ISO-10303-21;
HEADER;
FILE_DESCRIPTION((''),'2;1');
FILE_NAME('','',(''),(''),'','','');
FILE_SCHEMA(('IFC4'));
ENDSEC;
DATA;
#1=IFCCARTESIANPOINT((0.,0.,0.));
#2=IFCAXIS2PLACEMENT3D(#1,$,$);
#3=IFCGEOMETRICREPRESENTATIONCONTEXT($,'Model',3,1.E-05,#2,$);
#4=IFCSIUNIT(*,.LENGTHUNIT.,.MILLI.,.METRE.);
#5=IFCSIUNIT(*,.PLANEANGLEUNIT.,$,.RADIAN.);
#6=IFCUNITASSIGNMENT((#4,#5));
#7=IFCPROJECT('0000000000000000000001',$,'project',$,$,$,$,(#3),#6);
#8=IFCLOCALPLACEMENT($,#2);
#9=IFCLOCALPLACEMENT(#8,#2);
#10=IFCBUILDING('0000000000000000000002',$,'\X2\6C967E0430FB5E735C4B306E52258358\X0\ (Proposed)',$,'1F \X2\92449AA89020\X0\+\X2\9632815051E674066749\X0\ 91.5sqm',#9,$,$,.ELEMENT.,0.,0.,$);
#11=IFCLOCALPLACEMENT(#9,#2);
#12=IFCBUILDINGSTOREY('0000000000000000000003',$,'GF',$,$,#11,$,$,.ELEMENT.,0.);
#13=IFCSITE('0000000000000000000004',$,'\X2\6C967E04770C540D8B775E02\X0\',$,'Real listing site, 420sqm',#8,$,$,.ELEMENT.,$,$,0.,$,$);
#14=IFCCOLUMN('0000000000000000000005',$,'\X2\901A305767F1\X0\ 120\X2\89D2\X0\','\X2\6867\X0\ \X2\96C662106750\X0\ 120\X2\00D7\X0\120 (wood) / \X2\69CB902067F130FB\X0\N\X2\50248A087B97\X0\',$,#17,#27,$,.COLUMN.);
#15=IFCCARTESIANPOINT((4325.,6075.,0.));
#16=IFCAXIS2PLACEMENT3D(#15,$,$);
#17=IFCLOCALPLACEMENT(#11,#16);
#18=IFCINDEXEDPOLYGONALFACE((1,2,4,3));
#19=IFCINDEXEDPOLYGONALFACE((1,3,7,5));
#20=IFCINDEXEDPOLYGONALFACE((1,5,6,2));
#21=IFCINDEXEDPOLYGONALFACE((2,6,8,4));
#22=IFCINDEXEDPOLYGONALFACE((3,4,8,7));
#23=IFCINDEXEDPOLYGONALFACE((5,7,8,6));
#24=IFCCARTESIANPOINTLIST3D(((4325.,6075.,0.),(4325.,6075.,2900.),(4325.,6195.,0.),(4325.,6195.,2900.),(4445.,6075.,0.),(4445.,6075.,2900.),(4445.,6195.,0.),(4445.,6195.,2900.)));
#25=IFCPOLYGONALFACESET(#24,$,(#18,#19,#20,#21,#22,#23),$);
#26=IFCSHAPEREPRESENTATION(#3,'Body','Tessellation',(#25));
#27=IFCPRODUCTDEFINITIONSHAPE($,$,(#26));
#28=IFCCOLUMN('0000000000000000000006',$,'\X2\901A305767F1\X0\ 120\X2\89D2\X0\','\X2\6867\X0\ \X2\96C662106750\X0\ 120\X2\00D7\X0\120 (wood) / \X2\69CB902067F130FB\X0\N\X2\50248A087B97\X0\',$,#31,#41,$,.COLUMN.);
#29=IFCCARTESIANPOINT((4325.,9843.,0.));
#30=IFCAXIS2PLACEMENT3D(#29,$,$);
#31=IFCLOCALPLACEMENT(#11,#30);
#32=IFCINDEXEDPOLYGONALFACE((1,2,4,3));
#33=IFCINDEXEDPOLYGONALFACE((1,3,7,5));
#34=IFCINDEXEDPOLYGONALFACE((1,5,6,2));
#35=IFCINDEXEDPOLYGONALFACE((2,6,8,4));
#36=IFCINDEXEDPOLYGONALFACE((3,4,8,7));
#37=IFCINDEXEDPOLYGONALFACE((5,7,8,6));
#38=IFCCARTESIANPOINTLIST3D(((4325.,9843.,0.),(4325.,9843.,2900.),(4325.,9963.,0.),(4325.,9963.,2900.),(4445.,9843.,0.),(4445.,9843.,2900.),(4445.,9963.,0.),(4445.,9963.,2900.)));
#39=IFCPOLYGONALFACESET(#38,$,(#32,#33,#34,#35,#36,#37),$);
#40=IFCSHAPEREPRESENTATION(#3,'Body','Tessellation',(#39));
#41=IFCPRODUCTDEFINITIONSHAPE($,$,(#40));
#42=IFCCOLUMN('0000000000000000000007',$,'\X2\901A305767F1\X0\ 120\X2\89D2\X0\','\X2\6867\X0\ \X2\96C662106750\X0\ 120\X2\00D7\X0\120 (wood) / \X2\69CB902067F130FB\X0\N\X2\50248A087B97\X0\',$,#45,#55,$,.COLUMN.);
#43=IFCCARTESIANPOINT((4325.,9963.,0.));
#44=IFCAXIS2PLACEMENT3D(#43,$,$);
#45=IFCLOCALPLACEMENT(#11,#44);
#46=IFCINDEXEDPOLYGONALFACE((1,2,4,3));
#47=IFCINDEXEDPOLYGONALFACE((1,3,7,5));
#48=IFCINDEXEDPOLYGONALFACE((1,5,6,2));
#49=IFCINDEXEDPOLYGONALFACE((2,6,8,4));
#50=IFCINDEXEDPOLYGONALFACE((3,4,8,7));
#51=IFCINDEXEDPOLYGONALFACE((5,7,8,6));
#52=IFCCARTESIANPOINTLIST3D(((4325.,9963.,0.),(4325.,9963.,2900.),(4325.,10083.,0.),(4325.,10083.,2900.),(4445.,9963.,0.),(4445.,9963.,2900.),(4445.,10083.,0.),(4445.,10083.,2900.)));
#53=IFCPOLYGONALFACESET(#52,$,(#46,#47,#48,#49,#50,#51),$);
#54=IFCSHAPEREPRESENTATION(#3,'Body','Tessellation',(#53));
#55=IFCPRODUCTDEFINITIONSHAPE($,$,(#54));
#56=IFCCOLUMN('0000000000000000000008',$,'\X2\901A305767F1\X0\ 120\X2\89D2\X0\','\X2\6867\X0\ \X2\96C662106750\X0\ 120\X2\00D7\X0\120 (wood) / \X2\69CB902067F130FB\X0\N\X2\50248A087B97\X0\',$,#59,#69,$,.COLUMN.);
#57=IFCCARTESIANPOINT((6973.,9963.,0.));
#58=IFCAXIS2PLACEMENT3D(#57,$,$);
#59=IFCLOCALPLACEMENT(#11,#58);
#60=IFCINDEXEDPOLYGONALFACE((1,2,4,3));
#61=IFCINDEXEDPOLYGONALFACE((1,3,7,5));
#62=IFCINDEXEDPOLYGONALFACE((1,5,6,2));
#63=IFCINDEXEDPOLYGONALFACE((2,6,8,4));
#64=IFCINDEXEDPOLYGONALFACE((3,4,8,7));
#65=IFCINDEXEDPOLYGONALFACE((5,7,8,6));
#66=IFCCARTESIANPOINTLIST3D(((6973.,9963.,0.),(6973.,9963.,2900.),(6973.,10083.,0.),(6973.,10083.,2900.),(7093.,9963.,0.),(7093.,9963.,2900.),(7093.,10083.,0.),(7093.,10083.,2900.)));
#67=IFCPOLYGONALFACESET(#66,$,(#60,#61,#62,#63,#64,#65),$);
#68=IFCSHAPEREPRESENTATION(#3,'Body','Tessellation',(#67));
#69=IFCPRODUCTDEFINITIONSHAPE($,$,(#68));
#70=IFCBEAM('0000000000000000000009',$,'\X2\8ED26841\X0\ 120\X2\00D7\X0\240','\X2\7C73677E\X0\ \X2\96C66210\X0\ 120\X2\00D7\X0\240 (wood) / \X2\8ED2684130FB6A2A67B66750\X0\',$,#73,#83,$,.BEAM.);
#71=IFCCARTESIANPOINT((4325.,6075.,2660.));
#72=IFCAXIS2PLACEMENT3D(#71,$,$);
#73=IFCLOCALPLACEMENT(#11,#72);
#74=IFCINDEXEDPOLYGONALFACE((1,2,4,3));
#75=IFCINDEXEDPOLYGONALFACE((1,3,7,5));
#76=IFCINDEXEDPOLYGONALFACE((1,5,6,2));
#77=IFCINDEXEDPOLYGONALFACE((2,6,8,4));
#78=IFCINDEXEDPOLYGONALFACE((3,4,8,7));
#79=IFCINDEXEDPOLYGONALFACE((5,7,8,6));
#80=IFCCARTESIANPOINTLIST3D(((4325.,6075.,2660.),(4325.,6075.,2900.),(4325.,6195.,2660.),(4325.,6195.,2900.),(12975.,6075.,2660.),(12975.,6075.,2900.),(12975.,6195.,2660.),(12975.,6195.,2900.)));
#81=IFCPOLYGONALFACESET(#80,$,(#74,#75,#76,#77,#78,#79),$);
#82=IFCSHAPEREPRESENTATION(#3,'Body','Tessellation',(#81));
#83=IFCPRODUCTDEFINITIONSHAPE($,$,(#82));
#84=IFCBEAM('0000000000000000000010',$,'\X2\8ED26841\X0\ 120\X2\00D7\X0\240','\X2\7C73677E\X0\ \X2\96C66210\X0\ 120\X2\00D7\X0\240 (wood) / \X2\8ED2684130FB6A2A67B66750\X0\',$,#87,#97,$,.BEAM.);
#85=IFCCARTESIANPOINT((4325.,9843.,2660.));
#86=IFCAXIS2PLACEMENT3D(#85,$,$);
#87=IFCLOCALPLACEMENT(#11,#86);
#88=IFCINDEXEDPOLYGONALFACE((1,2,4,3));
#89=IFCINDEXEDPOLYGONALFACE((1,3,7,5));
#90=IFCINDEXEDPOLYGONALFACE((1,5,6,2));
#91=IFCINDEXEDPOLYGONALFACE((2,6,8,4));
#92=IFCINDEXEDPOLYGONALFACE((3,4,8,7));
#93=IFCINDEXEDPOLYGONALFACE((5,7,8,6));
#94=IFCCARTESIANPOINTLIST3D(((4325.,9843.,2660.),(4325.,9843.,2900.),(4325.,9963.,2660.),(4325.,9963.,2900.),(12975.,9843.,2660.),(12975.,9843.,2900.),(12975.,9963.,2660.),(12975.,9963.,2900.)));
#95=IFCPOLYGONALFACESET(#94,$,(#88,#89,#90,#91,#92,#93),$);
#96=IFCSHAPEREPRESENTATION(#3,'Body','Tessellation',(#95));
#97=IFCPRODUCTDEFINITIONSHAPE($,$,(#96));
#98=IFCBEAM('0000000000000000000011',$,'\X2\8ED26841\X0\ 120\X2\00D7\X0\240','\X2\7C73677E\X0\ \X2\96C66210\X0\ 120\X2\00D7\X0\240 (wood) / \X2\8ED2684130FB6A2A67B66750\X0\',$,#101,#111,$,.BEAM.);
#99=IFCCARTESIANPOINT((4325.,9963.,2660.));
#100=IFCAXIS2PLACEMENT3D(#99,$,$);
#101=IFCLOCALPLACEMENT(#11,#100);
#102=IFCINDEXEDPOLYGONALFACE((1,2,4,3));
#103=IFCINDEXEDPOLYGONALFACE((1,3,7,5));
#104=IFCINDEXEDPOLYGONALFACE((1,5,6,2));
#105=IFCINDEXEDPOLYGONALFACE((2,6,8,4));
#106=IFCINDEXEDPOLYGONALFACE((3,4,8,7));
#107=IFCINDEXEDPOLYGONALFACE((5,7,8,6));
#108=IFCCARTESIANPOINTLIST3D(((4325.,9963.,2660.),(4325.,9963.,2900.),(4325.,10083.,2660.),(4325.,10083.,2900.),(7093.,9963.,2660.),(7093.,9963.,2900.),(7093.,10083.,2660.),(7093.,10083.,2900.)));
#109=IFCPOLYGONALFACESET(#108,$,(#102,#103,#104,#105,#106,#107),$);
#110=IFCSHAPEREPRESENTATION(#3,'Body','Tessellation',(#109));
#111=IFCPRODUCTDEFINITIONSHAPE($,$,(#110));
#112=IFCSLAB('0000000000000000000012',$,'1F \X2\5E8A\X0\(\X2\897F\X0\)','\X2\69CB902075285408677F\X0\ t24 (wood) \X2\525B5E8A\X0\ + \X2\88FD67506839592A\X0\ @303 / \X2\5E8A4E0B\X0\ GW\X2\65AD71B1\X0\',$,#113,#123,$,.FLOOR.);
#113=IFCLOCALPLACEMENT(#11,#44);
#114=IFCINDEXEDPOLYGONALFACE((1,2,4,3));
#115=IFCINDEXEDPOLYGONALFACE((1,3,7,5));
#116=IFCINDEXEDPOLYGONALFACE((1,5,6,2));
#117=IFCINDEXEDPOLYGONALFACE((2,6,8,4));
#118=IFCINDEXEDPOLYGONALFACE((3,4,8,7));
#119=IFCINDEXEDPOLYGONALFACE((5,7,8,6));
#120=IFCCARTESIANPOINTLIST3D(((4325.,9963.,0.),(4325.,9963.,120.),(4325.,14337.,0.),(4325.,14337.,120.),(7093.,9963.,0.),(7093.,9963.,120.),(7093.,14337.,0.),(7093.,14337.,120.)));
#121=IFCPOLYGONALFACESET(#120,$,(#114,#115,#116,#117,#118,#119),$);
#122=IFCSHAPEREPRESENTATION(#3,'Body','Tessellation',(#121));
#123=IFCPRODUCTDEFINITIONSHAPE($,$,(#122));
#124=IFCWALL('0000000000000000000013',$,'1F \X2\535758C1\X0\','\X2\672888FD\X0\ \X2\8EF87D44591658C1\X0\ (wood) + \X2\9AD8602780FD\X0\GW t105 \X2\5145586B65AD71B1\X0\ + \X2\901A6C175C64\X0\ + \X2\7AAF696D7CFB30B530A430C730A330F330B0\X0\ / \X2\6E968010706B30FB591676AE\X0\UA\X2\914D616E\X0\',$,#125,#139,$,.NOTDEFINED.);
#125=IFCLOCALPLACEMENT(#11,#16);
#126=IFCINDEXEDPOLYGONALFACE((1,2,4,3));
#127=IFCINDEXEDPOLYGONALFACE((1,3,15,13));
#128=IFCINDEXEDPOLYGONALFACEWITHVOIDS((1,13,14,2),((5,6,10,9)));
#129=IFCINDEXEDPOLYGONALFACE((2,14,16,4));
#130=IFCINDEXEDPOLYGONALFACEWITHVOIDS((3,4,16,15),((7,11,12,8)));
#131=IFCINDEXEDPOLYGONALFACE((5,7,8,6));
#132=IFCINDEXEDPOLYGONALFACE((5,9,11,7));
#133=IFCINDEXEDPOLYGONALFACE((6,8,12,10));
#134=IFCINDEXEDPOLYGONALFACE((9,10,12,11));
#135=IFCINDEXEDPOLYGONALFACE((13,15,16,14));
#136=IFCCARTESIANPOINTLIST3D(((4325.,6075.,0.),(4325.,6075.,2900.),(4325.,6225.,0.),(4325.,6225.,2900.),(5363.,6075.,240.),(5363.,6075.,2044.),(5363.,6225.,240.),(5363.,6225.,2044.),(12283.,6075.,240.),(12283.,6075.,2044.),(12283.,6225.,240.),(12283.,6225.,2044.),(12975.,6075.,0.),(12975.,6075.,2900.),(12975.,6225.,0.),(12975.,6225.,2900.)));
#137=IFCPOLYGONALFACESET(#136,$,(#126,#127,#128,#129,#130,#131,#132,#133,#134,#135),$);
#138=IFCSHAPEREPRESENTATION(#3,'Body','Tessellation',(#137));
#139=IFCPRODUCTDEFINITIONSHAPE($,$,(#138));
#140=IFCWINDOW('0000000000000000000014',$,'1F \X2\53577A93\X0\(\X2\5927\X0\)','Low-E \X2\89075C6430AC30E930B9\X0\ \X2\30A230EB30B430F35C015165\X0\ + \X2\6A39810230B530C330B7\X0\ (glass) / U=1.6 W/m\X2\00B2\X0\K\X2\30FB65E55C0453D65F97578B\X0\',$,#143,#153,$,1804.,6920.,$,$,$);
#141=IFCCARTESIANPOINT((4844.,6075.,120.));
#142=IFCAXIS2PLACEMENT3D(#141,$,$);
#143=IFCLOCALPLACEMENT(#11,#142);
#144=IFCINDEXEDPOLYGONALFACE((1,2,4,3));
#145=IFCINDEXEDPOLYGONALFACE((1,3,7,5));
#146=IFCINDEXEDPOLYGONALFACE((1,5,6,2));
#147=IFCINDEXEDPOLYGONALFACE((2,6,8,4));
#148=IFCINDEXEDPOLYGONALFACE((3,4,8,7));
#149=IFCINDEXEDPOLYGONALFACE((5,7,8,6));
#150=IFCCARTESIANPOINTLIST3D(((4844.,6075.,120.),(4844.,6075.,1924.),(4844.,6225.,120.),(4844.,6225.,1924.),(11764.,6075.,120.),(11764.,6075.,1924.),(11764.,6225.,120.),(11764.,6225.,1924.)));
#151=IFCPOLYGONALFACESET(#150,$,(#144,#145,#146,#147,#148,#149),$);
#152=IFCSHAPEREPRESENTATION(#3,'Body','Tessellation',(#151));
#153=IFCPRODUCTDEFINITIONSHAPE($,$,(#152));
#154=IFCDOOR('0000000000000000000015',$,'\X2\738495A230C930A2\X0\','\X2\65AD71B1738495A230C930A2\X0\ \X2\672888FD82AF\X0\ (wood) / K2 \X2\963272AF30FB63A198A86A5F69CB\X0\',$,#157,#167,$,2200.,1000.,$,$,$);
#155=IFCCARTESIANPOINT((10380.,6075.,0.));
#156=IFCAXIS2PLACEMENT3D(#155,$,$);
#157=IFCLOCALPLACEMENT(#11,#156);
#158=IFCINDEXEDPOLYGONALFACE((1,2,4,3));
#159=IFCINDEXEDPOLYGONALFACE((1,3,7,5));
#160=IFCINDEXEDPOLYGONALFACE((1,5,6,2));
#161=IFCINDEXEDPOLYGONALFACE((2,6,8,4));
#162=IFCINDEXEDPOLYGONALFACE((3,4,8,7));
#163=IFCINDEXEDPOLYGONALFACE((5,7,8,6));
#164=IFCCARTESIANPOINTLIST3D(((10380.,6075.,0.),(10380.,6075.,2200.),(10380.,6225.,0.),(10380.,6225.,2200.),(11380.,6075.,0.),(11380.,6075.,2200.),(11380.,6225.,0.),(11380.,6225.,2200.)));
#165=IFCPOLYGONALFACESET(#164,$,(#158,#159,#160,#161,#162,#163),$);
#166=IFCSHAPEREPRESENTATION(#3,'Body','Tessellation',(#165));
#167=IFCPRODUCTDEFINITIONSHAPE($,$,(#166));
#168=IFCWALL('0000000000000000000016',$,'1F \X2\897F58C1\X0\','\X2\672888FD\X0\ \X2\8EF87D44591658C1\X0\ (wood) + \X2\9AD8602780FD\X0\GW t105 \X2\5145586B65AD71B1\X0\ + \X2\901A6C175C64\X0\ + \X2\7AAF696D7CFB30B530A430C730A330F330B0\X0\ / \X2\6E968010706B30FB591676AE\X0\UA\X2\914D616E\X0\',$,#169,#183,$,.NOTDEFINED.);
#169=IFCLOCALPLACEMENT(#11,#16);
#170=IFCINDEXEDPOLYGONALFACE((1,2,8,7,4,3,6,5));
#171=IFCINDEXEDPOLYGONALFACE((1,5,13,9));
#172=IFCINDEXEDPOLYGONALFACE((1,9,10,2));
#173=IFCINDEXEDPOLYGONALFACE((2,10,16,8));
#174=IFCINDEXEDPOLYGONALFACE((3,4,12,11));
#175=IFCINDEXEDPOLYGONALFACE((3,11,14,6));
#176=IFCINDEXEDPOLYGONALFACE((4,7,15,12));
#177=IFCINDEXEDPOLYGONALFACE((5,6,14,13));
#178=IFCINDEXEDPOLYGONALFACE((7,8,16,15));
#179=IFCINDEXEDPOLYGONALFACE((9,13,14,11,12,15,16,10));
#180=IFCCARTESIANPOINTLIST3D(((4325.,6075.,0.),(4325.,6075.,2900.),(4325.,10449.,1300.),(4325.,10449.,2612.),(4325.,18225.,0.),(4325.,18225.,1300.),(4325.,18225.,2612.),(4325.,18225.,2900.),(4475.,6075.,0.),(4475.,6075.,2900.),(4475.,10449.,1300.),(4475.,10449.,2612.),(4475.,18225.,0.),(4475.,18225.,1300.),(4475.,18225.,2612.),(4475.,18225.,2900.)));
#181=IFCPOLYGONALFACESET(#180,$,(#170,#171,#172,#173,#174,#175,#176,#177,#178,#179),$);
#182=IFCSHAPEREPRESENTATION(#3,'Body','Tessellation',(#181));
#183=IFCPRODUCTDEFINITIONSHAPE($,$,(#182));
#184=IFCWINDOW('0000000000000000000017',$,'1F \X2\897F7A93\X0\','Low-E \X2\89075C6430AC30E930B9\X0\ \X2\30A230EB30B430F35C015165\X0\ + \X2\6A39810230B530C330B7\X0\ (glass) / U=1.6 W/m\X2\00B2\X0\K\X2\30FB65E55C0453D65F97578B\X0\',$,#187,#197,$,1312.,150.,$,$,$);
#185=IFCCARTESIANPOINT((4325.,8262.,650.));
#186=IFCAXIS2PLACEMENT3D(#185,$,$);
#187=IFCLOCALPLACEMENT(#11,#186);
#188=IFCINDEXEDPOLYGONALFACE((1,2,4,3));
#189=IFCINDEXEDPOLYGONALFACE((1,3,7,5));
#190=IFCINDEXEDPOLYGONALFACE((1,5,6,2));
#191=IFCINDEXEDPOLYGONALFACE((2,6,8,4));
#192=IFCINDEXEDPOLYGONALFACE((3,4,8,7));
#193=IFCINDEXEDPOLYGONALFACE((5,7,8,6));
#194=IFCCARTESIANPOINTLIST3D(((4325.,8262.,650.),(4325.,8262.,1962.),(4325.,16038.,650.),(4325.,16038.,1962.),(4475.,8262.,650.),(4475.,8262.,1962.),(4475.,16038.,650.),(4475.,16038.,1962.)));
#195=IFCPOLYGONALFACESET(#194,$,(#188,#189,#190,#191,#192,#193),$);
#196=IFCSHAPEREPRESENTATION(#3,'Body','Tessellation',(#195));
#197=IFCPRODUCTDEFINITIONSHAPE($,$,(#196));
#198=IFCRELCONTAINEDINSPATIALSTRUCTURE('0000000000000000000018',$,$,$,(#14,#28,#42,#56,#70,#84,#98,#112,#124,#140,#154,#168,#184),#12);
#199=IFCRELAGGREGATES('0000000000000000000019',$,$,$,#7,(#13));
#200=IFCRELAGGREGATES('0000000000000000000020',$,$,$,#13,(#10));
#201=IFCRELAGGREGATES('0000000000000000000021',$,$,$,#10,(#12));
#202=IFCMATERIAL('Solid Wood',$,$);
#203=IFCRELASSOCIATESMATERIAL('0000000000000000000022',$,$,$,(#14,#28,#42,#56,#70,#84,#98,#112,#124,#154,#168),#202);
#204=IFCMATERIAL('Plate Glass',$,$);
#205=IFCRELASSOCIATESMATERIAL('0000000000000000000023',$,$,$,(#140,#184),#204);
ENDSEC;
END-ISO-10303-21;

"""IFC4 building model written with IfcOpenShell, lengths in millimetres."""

from ifc_helpers import new_model, si_unit, frame, frame_2d, origin, place, context, project, spatial, rectangle, extrude, material, element, fill, save


model = new_model("IFC4")

# Units and contexts
model_context = context("Model", 3, precision=1e-05, world=origin())
ifc_project = project(units=[si_unit("LENGTHUNIT", "METRE", prefix="MILLI"), si_unit("PLANEANGLEUNIT", "RADIAN")], contexts=[model_context])

# Site, building, storey
site_placement = place(None, origin())
site = spatial("IfcSite", under=ifc_project, at=site_placement, Name="沖縄県名護市", ObjectType="Real listing site, 420sqm", CompositionType="ELEMENT", RefElevation=0.0)
building_placement = place(site_placement, origin())
building = spatial("IfcBuilding", under=site, at=building_placement, Name="沖縄・平屋の別荘 (Proposed)", ObjectType="1F 鉄骨造+防腐処理杉 91.5sqm", CompositionType="ELEMENT", ElevationOfRefHeight=0.0, ElevationOfTerrain=0.0)
storey_placement = place(building_placement, origin())
storey = spatial("IfcBuildingStorey", under=building, at=storey_placement, Name="GF", CompositionType="ELEMENT", Elevation=0.0)

# Columns
ifc_material_1 = material(Name="Solid Wood")
column_1_placement = place(storey_placement, frame((4325.0, 6075.0, 0.0)))
element("IfcColumn", 1, at=column_1_placement, inside=storey, material=ifc_material_1, Name="通し柱 120角", Description="桧 集成材 120×120 (wood) / 構造柱・N値計算", PredefinedType="COLUMN", context=model_context, shape_type="SweptSolid", body=[
    extrude(rectangle(XDim=120.0, YDim=120.0, at=frame_2d((60.0, 60.0))), frame((4325.0, 6075.0, 0.0)), (0.0, 0.0, 1.0), 2900.0),
])
column_2_placement = place(storey_placement, frame((4325.0, 9843.0, 0.0)))
element("IfcColumn", 2, at=column_2_placement, inside=storey, material=ifc_material_1, Name="通し柱 120角", Description="桧 集成材 120×120 (wood) / 構造柱・N値計算", PredefinedType="COLUMN", context=model_context, shape_type="SweptSolid", body=[
    extrude(rectangle(XDim=120.0, YDim=120.0, at=frame_2d((60.0, 60.0))), frame((4325.0, 9843.0, 0.0)), (0.0, 0.0, 1.0), 2900.0),
])
column_3_placement = place(storey_placement, frame((4325.0, 9963.0, 0.0)))
element("IfcColumn", 3, at=column_3_placement, inside=storey, material=ifc_material_1, Name="通し柱 120角", Description="桧 集成材 120×120 (wood) / 構造柱・N値計算", PredefinedType="COLUMN", context=model_context, shape_type="SweptSolid", body=[
    extrude(rectangle(XDim=120.0, YDim=120.0, at=frame_2d((60.0, 60.0))), frame((4325.0, 9963.0, 0.0)), (0.0, 0.0, 1.0), 2900.0),
])
column_4_placement = place(storey_placement, frame((6973.0, 9963.0, 0.0)))
element("IfcColumn", 4, at=column_4_placement, inside=storey, material=ifc_material_1, Name="通し柱 120角", Description="桧 集成材 120×120 (wood) / 構造柱・N値計算", PredefinedType="COLUMN", context=model_context, shape_type="SweptSolid", body=[
    extrude(rectangle(XDim=120.0, YDim=120.0, at=frame_2d((60.0, 60.0))), frame((6973.0, 9963.0, 0.0)), (0.0, 0.0, 1.0), 2900.0),
])

# Beams
beam_1_placement = place(storey_placement, frame((4325.0, 6075.0, 2660.0)))
element("IfcBeam", 5, at=beam_1_placement, inside=storey, material=ifc_material_1, Name="軒桁 120×240", Description="米松 集成 120×240 (wood) / 軒桁・横架材", PredefinedType="BEAM", context=model_context, shape_type="SweptSolid", body=[
    extrude(rectangle(XDim=8650.0, YDim=120.0, at=frame_2d((4325.0, 60.0))), frame((4325.0, 6075.0, 2660.0)), (0.0, 0.0, 1.0), 240.0),
])
beam_2_placement = place(storey_placement, frame((4325.0, 9843.0, 2660.0)))
element("IfcBeam", 6, at=beam_2_placement, inside=storey, material=ifc_material_1, Name="軒桁 120×240", Description="米松 集成 120×240 (wood) / 軒桁・横架材", PredefinedType="BEAM", context=model_context, shape_type="SweptSolid", body=[
    extrude(rectangle(XDim=8650.0, YDim=120.0, at=frame_2d((4325.0, 60.0))), frame((4325.0, 9843.0, 2660.0)), (0.0, 0.0, 1.0), 240.0),
])
beam_3_placement = place(storey_placement, frame((4325.0, 9963.0, 2660.0)))
element("IfcBeam", 7, at=beam_3_placement, inside=storey, material=ifc_material_1, Name="軒桁 120×240", Description="米松 集成 120×240 (wood) / 軒桁・横架材", PredefinedType="BEAM", context=model_context, shape_type="SweptSolid", body=[
    extrude(rectangle(XDim=2768.0, YDim=120.0, at=frame_2d((1384.0, 60.0))), frame((4325.0, 9963.0, 2660.0)), (0.0, 0.0, 1.0), 240.0),
])

# Slab
slab_1_placement = place(storey_placement, frame((4325.0, 9963.0, 0.0)))
element("IfcSlab", 8, at=slab_1_placement, inside=storey, material=ifc_material_1, Name="1F 床(西)", Description="構造用合板 t24 (wood) 剛床 + 製材根太 @303 / 床下 GW断熱", PredefinedType="FLOOR", context=model_context, shape_type="SweptSolid", body=[
    extrude(rectangle(XDim=2768.0, YDim=4374.0, at=frame_2d((1384.0, 2187.0))), frame((4325.0, 9963.0, 0.0)), (0.0, 0.0, 1.0), 120.0),
])

# Wall, openings, window, door
wall_1_placement = place(storey_placement, frame((4325.0, 6075.0, 0.0)))
wall_1 = element("IfcWall", 9, at=wall_1_placement, inside=storey, material=ifc_material_1, Name="1F 南壁", Description="木製 軸組外壁 (wood) + 高性能GW t105 充填断熱 + 通気層 + 窯業系サイディング / 準耐火・外皮UA配慮", PredefinedType="NOTDEFINED", context=model_context, shape_type="SweptSolid", body=[
    extrude(rectangle(XDim=8650.0, YDim=150.0, at=frame_2d((4325.0, 75.0))), frame((4325.0, 6075.0, 0.0)), (0.0, 0.0, 1.0), 2900.0),
])
opening_1_placement = place(storey_placement, frame((4844.0, 6075.0, 120.0)))
opening_1 = element("IfcOpeningElement", 10, at=opening_1_placement, cuts=wall_1, PredefinedType="NOTDEFINED", context=model_context, shape_type="SweptSolid", body=[
    extrude(rectangle(XDim=6920.0, YDim=150.0, at=frame_2d((3460.0, 75.0))), frame((4844.0, 6075.0, 120.0)), (0.0, 0.0, 1.0), 1804.0),
])
opening_2_placement = place(storey_placement, frame((10380.0, 6075.0, 0.0)))
opening_2 = element("IfcOpeningElement", 11, at=opening_2_placement, cuts=wall_1, PredefinedType="NOTDEFINED", context=model_context, shape_type="SweptSolid", body=[
    extrude(rectangle(XDim=1000.0, YDim=150.0, at=frame_2d((500.0, 75.0))), frame((10380.0, 6075.0, 0.0)), (0.0, 0.0, 1.0), 2200.0),
])
ifc_material_2 = material(Name="Plate Glass")
window_1_placement = place(storey_placement, frame((4844.0, 6075.0, 120.0)))
window_1 = element("IfcWindow", 12, at=window_1_placement, inside=storey, material=ifc_material_2, Name="1F 南窓(大)", Description="Low-E 複層ガラス アルゴン封入 + 樹脂サッシ (glass) / U=1.6 W/m²K・日射取得型", OverallHeight=1804.0, OverallWidth=6920.0, context=model_context, shape_type="SweptSolid", body=[
    extrude(rectangle(XDim=6920.0, YDim=150.0, at=frame_2d((3460.0, 75.0))), frame((4844.0, 6075.0, 120.0)), (0.0, 0.0, 1.0), 1804.0),
])
fill(opening_1, window_1)
door_placement = place(storey_placement, frame((10380.0, 6075.0, 0.0)))
door = element("IfcDoor", 13, at=door_placement, inside=storey, material=ifc_material_1, Name="玄関ドア", Description="断熱玄関ドア 木製芯 (wood) / K2 防犯・採風機構", OverallHeight=2200.0, OverallWidth=1000.0, context=model_context, shape_type="SweptSolid", body=[
    extrude(rectangle(XDim=1000.0, YDim=150.0, at=frame_2d((500.0, 75.0))), frame((10380.0, 6075.0, 0.0)), (0.0, 0.0, 1.0), 2200.0),
])
fill(opening_2, door)

# Wall, opening, window
wall_2_placement = place(storey_placement, frame((4325.0, 6075.0, 0.0)))
wall_2 = element("IfcWall", 14, at=wall_2_placement, inside=storey, material=ifc_material_1, Name="1F 西壁", Description="木製 軸組外壁 (wood) + 高性能GW t105 充填断熱 + 通気層 + 窯業系サイディング / 準耐火・外皮UA配慮", PredefinedType="NOTDEFINED", context=model_context, shape_type="SweptSolid", body=[
    extrude(rectangle(XDim=150.0, YDim=12150.0, at=frame_2d((75.0, 6075.0))), frame((4325.0, 6075.0, 0.0)), (0.0, 0.0, 1.0), 2900.0),
])
opening_3_placement = place(storey_placement, frame((4325.0, 8262.0, 650.0)))
opening_3 = element("IfcOpeningElement", 15, at=opening_3_placement, cuts=wall_2, PredefinedType="NOTDEFINED", context=model_context, shape_type="SweptSolid", body=[
    extrude(rectangle(XDim=150.0, YDim=7776.0, at=frame_2d((75.0, 3888.0))), frame((4325.0, 8262.0, 650.0)), (0.0, 0.0, 1.0), 1312.0),
])
window_2_placement = place(storey_placement, frame((4325.0, 8262.0, 650.0)))
window_2 = element("IfcWindow", 16, at=window_2_placement, inside=storey, material=ifc_material_2, Name="1F 西窓", Description="Low-E 複層ガラス アルゴン封入 + 樹脂サッシ (glass) / U=1.6 W/m²K・日射取得型", OverallHeight=1312.0, OverallWidth=150.0, context=model_context, shape_type="SweptSolid", body=[
    extrude(rectangle(XDim=150.0, YDim=7776.0, at=frame_2d((75.0, 3888.0))), frame((4325.0, 8262.0, 650.0)), (0.0, 0.0, 1.0), 1312.0),
])
fill(opening_3, window_2)

save(model, "model.ifc")
